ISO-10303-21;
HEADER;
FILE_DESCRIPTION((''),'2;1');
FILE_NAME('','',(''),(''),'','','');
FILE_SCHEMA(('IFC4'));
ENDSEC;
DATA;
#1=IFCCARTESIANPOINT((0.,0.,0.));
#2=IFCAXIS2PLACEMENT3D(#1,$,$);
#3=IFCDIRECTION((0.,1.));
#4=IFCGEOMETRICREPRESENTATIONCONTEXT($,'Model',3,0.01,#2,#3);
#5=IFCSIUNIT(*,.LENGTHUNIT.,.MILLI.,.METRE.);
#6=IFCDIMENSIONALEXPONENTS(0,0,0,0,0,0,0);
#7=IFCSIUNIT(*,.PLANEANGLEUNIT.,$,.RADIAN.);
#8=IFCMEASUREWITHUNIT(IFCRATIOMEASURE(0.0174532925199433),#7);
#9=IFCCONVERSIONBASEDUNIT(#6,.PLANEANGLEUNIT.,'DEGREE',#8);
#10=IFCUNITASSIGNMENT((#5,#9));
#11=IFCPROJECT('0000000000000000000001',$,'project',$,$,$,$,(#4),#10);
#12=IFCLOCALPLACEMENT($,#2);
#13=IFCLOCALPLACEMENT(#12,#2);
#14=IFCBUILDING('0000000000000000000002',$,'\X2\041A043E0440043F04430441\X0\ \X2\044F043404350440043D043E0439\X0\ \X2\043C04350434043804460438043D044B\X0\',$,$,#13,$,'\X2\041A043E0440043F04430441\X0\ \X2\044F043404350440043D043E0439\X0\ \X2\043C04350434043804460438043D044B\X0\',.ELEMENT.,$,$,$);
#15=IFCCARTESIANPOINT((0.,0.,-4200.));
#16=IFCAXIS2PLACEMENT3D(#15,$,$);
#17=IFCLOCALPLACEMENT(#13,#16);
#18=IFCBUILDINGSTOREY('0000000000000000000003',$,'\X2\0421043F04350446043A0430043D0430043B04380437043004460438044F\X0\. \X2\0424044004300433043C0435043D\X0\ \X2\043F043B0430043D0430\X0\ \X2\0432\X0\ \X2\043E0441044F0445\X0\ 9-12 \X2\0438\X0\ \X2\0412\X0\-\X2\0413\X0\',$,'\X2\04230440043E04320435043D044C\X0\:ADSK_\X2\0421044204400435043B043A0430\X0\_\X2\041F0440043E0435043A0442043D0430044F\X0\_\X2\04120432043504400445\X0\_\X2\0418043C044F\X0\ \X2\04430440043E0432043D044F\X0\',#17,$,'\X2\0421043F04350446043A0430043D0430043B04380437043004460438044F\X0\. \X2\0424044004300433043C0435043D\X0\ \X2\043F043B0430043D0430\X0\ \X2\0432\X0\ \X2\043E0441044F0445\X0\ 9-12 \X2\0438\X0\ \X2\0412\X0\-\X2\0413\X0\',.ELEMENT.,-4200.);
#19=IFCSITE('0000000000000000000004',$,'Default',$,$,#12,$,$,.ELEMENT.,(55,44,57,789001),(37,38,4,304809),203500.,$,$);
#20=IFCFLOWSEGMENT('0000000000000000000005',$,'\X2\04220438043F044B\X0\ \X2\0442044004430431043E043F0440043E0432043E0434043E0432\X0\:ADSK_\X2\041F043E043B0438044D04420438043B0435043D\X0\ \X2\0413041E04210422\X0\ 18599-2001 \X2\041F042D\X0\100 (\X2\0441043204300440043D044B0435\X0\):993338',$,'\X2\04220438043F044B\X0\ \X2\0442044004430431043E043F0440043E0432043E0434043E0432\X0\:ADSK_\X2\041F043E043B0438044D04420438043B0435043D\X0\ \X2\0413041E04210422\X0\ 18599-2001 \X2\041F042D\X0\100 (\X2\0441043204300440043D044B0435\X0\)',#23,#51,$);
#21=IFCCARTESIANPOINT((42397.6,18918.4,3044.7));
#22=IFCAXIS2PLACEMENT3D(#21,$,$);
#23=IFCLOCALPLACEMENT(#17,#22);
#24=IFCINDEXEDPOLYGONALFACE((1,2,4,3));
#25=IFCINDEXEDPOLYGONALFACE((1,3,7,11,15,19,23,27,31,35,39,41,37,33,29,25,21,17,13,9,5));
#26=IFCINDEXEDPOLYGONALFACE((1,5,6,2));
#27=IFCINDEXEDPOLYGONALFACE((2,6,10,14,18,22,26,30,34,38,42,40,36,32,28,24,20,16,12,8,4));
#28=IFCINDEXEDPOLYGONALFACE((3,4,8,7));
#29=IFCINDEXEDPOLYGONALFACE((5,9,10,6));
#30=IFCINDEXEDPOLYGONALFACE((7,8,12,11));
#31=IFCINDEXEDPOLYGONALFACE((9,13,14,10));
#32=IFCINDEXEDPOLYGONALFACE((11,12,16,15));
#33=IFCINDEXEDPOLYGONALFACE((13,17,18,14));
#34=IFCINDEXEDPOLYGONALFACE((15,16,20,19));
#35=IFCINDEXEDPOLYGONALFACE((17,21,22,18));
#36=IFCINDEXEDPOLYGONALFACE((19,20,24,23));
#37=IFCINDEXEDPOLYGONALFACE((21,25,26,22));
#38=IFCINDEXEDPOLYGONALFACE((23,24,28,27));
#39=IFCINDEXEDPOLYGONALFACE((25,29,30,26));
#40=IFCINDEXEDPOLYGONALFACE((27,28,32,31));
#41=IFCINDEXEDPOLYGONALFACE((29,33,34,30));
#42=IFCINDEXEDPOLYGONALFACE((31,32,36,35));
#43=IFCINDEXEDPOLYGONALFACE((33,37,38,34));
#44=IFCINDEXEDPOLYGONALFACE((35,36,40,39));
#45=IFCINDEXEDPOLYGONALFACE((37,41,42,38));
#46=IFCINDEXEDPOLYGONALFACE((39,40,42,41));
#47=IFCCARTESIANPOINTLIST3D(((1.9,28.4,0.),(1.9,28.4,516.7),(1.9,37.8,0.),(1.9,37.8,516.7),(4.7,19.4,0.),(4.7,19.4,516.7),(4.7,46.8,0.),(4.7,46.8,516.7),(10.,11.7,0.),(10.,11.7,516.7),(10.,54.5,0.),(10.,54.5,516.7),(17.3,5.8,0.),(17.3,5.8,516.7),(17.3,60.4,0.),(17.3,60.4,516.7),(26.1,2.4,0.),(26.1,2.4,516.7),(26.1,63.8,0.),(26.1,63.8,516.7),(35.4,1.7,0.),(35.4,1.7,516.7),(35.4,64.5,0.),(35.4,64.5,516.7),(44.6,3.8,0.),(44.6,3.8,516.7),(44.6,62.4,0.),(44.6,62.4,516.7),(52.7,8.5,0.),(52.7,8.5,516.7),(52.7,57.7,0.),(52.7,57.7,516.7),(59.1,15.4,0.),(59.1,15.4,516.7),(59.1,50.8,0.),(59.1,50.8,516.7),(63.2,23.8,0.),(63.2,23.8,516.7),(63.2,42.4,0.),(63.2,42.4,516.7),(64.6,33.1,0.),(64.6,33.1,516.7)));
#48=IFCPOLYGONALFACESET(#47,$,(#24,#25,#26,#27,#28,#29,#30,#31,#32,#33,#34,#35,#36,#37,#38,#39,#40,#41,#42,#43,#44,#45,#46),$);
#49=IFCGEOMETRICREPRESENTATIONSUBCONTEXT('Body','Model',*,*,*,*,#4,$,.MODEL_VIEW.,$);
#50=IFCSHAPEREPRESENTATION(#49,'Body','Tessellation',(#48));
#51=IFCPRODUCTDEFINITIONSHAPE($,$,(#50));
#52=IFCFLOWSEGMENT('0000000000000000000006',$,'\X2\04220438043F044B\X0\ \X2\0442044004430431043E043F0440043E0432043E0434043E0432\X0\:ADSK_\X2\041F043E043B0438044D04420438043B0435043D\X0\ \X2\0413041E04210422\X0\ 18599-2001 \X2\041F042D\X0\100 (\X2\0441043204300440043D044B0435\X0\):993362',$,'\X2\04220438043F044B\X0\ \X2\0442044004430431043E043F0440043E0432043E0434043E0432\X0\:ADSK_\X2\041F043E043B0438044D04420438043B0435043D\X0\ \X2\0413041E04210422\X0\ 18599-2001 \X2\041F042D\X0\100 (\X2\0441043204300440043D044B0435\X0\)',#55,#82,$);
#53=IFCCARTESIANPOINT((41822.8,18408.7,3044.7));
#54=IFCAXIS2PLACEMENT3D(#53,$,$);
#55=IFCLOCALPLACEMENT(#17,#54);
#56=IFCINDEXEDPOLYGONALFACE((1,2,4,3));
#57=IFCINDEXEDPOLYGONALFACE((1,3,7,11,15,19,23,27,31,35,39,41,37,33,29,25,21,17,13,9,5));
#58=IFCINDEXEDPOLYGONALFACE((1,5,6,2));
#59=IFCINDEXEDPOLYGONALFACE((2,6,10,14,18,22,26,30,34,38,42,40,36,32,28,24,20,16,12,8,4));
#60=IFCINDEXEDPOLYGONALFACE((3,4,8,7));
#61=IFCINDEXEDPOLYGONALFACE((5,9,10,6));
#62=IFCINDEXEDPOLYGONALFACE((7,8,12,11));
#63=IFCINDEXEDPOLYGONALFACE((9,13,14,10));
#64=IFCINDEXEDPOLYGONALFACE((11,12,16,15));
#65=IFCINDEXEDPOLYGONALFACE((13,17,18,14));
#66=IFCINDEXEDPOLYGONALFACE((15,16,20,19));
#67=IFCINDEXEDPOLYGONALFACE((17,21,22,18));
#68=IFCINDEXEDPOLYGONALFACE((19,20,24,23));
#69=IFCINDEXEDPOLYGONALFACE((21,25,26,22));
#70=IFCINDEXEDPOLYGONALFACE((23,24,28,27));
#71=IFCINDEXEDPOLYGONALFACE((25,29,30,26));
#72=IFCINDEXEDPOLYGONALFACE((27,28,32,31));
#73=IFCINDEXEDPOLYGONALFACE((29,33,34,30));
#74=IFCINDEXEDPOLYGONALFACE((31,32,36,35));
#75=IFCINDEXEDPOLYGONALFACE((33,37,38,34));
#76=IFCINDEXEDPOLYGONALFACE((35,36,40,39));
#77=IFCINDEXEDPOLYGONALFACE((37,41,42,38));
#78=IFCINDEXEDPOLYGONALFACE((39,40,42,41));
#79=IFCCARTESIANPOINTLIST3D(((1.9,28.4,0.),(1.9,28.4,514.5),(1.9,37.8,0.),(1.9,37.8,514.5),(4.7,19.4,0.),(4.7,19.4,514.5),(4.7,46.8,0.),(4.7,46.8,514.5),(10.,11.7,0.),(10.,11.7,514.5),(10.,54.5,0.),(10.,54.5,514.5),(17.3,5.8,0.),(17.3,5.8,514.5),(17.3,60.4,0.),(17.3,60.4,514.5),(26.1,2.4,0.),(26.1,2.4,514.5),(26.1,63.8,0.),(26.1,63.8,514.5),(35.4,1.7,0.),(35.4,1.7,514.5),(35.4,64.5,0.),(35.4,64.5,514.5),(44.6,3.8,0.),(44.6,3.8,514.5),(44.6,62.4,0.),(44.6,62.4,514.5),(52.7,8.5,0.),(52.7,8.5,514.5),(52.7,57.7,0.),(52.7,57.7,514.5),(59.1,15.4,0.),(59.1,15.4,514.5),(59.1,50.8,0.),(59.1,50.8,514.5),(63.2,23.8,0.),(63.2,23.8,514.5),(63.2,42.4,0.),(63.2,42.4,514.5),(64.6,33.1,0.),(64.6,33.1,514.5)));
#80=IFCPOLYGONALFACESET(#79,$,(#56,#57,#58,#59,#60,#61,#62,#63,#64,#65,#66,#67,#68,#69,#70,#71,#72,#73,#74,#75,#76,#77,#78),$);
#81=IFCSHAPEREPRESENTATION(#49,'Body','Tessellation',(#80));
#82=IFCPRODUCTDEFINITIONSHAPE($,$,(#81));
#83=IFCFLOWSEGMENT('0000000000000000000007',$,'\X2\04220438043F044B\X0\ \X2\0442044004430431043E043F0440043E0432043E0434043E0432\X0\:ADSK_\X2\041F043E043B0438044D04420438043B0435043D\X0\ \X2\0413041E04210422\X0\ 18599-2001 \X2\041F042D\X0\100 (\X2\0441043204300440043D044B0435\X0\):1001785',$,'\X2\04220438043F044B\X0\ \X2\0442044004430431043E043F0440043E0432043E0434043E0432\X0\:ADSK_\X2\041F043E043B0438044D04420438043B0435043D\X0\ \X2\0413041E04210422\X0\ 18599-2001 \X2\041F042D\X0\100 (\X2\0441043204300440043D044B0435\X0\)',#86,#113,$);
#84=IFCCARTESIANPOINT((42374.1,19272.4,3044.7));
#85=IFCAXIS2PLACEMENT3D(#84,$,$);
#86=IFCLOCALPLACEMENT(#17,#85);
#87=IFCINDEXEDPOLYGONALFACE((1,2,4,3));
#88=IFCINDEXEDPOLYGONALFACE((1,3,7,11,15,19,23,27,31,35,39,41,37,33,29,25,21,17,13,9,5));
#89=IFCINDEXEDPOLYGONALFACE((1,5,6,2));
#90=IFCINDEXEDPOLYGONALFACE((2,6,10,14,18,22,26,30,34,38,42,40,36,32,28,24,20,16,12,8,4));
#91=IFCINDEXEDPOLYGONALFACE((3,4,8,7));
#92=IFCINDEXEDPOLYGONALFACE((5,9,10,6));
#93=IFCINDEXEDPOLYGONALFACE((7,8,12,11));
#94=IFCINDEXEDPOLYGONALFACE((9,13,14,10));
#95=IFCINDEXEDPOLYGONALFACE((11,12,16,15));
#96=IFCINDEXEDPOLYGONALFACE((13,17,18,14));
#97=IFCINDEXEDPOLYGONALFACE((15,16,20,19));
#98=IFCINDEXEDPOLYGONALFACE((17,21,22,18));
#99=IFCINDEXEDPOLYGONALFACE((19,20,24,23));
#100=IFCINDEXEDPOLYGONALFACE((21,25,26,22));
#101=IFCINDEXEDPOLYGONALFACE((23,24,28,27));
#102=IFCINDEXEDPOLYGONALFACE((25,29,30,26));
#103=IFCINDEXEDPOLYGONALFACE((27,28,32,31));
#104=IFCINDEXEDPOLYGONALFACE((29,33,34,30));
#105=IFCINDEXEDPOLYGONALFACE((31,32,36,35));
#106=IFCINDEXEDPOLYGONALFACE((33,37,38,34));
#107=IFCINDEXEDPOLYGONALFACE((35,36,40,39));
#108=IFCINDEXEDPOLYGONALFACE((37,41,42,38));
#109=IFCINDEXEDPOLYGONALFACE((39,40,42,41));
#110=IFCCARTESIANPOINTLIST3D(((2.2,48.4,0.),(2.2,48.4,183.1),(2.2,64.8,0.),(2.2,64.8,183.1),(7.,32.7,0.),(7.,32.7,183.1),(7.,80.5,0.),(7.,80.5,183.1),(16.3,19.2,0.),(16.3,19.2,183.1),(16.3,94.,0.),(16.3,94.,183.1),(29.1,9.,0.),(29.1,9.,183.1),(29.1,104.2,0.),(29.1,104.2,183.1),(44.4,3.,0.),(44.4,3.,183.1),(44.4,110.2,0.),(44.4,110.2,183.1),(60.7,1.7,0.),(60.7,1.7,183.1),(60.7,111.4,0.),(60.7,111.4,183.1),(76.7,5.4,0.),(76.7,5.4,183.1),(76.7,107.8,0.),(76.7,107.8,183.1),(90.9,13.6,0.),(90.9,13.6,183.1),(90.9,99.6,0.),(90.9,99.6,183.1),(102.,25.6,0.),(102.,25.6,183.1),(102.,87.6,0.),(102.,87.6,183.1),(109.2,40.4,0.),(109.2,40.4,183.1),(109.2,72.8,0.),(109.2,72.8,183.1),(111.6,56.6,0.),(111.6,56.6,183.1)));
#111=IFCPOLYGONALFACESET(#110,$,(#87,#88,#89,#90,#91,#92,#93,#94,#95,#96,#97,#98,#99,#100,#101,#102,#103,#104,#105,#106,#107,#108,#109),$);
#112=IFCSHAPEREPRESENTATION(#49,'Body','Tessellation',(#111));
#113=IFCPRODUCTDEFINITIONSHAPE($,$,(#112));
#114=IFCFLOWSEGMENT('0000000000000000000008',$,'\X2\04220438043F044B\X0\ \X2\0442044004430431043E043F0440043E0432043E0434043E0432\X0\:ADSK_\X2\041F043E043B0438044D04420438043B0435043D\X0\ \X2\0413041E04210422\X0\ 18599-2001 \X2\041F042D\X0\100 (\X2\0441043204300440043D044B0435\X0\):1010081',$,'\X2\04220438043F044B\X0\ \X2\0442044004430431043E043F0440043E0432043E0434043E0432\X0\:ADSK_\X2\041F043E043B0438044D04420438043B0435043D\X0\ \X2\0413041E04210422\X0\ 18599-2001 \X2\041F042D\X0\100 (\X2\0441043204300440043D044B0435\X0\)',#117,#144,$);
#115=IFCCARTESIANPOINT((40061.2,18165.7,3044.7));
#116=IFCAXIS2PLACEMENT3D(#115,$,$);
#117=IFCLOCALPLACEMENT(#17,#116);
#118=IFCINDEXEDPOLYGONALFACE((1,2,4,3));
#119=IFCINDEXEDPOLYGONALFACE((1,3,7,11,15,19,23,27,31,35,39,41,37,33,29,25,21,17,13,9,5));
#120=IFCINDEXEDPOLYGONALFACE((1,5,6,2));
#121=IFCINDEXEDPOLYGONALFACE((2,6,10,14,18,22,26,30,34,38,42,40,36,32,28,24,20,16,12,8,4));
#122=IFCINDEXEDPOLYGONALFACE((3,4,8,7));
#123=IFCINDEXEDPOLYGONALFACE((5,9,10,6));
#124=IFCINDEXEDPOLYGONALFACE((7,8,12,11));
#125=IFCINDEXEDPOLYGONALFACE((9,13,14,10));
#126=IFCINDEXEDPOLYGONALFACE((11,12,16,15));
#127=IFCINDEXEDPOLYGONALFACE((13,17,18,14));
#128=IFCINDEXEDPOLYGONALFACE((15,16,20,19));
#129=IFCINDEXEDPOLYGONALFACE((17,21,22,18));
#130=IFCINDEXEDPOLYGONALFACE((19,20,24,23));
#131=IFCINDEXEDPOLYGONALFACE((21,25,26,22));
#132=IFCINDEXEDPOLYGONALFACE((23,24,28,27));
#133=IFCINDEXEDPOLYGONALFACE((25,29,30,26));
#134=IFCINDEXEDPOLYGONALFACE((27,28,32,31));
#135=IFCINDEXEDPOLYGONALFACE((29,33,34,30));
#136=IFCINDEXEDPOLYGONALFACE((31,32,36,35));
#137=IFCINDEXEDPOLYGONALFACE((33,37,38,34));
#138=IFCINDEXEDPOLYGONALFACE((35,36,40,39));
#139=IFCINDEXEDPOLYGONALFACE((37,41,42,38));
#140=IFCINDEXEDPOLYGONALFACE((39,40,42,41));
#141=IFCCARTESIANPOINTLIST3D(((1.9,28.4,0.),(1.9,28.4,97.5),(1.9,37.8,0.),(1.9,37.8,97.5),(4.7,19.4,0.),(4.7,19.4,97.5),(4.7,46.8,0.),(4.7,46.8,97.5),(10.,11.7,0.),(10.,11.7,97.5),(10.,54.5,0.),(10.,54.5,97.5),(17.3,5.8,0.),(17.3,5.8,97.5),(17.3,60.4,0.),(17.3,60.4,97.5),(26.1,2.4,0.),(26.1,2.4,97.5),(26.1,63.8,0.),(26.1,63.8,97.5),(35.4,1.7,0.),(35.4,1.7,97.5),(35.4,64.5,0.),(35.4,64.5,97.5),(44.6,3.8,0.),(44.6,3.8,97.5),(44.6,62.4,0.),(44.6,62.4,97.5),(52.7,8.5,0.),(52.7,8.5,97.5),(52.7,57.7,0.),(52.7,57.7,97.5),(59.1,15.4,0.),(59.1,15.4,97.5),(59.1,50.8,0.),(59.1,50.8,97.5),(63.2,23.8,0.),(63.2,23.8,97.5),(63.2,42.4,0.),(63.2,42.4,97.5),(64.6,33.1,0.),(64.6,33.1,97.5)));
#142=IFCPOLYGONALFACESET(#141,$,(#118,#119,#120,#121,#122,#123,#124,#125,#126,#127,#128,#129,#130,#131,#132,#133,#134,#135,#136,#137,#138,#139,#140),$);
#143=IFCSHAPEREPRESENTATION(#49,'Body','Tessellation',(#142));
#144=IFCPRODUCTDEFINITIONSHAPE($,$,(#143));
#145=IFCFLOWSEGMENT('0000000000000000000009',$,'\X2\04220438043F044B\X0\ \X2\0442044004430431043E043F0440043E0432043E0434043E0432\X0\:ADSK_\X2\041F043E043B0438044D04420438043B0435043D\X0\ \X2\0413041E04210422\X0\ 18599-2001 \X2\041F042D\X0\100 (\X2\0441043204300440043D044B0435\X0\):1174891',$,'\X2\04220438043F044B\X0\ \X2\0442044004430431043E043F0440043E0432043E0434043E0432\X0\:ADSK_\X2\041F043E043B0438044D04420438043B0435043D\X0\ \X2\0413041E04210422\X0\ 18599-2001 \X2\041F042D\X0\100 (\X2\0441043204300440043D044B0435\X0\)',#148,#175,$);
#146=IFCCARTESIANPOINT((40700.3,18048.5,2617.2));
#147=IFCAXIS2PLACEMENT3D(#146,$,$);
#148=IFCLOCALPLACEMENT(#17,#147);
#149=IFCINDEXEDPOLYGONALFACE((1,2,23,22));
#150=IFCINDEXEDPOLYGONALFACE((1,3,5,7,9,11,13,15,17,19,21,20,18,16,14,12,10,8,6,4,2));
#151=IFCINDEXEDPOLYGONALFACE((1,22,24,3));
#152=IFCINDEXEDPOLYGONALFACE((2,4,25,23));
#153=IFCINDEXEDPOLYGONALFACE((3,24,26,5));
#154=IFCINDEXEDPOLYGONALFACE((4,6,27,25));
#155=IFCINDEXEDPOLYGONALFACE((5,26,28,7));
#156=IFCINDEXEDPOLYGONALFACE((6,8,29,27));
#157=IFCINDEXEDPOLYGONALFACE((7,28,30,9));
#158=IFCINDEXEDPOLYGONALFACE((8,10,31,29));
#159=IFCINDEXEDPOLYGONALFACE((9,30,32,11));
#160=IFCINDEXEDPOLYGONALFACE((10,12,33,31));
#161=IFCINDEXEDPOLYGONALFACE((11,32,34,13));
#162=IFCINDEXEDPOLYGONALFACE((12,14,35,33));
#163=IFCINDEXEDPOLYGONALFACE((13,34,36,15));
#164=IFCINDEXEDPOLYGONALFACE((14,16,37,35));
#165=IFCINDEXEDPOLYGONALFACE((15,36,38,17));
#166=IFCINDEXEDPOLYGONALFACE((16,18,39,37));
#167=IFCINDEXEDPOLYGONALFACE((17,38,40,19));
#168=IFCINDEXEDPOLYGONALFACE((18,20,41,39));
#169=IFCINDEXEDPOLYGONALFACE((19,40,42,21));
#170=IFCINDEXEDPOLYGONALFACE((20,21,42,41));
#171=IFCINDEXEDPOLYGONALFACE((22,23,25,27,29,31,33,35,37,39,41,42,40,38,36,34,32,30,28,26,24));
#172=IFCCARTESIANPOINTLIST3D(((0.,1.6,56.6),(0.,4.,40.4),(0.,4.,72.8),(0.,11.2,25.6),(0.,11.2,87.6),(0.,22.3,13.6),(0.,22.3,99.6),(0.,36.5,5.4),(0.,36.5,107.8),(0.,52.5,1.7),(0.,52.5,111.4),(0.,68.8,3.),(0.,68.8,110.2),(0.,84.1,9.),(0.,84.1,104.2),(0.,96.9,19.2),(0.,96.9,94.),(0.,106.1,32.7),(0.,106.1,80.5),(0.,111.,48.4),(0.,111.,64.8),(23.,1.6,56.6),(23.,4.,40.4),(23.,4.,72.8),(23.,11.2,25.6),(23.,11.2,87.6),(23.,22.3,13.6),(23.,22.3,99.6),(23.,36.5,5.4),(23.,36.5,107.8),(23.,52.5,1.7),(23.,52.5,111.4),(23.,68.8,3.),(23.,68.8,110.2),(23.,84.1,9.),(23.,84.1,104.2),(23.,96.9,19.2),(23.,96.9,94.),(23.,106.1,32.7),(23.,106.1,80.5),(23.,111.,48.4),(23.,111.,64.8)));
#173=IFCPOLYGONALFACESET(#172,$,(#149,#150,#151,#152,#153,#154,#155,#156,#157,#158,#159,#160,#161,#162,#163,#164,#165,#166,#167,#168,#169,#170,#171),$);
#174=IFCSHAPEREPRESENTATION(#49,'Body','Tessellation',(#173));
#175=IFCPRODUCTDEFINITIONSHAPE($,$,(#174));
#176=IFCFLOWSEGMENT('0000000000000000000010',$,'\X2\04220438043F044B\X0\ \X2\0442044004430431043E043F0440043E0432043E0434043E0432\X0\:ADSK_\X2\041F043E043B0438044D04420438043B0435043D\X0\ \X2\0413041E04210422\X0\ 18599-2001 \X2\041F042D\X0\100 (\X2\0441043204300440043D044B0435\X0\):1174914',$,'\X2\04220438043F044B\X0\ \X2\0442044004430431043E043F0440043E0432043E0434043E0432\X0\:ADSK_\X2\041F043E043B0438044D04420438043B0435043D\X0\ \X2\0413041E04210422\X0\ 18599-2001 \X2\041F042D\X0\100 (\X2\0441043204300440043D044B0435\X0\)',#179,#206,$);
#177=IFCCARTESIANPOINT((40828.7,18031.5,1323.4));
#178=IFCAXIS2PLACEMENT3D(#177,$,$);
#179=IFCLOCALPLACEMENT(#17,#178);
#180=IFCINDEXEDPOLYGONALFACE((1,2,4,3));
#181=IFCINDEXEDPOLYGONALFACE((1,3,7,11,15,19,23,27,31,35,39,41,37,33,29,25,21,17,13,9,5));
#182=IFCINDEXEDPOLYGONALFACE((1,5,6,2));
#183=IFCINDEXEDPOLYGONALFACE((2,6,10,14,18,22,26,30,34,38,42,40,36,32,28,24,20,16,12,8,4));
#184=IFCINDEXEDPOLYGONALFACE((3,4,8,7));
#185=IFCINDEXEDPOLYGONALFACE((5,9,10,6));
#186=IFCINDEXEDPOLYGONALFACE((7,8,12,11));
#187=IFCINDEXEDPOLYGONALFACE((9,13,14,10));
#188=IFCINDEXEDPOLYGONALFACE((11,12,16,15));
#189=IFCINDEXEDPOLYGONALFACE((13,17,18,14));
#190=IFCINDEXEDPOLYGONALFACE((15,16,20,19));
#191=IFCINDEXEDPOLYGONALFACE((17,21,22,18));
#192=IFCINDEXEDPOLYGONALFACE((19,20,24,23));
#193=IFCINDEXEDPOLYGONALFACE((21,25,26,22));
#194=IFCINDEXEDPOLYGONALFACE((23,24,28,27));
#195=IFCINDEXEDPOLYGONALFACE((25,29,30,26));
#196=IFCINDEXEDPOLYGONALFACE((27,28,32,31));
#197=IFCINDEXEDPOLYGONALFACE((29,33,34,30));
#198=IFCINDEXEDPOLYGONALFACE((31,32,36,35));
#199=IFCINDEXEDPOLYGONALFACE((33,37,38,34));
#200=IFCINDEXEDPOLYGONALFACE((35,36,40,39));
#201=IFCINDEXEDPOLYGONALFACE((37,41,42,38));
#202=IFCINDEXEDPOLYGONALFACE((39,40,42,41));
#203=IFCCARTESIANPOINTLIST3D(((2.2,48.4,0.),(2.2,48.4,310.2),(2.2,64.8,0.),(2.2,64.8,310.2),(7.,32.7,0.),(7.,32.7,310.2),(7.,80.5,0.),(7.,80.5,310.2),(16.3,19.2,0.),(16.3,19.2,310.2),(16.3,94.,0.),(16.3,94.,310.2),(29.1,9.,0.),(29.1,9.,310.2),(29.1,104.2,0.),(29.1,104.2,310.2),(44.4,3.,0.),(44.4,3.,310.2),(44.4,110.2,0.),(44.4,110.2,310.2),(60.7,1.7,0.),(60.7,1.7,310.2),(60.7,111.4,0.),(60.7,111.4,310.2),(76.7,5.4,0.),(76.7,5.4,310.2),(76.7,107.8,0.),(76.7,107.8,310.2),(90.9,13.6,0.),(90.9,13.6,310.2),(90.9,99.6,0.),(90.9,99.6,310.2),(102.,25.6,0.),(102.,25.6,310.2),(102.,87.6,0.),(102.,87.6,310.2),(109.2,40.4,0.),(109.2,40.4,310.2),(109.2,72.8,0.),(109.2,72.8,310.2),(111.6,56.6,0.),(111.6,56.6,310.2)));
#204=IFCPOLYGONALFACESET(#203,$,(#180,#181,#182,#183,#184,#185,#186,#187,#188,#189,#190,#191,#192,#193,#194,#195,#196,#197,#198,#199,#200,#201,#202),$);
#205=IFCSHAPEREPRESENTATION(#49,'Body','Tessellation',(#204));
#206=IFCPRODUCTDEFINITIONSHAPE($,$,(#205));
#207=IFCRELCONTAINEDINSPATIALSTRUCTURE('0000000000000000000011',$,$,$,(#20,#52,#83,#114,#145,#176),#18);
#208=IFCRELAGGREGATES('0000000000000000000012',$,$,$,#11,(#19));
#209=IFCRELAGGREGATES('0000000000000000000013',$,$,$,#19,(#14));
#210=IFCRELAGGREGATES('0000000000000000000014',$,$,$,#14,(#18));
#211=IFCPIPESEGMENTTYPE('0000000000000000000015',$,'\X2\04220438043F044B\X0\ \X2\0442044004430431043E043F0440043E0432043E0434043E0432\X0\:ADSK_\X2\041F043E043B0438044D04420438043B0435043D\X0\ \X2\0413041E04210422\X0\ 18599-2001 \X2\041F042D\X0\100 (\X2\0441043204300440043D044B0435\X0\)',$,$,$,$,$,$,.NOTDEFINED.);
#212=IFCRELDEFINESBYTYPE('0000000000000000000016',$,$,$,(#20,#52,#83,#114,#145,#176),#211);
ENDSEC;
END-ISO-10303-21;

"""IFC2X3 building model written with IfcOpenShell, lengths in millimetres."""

from ifc_helpers import new_model, entity, si_unit, converted_unit, direction, frame, frame_2d, origin, origin_2d_with_axis, place, context, subcontext, project, spatial, circle, extrude, type_object, element, save


model = new_model("IFC2X3")

# Units and contexts
model_context = context("Model", 3, precision=0.01, world=origin(), true_north=direction((0.0, 1.0)))
body_context = subcontext(model_context, "Body", "Model", "MODEL_VIEW")
ifc_project = project(units=[si_unit("LENGTHUNIT", "METRE", prefix="MILLI"), converted_unit("PLANEANGLEUNIT", "DEGREE", entity("IfcRatioMeasure", 0.0174532925199433), si_unit("PLANEANGLEUNIT", "RADIAN"), dimensions=[0, 0, 0, 0, 0, 0, 0])], contexts=[model_context])

# Site, building, storey
site_placement = place(None, frame((0.0, 0.0, 0.0)))
site = spatial("IfcSite", under=ifc_project, at=site_placement, Name="Default", CompositionType="ELEMENT", RefLatitude=(55, 44, 57, 789001), RefLongitude=(37, 38, 4, 304809), RefElevation=203500.0)
building_placement = place(site_placement, origin())
building = spatial("IfcBuilding", under=site, at=building_placement, Name="Корпус ядерной медицины", LongName="Корпус ядерной медицины", CompositionType="ELEMENT")
storey_placement = place(building_placement, frame((0.0, 0.0, -4200.0)))
storey = spatial("IfcBuildingStorey", under=building, at=storey_placement, Name="Спецканализация. Фрагмен плана в осях 9-12 и В-Г", ObjectType="Уровень:ADSK_Стрелка_Проектная_Вверх_Имя уровня", LongName="Спецканализация. Фрагмен плана в осях 9-12 и В-Г", CompositionType="ELEMENT", Elevation=-4200.0)

# Flow segments
pipe_segment_type = type_object("IfcPipeSegmentType", Name="Типы трубопроводов:ADSK_Полиэтилен ГОСТ 18599-2001 ПЭ100 (сварные)", PredefinedType="NOTDEFINED")
flow_segment_1_placement = place(storey_placement, frame((42397.6, 18918.4, 3044.7)))
element("IfcFlowSegment", 1, at=flow_segment_1_placement, inside=storey, type_object=pipe_segment_type, Name="Типы трубопроводов:ADSK_Полиэтилен ГОСТ 18599-2001 ПЭ100 (сварные):993338", ObjectType="Типы трубопроводов:ADSK_Полиэтилен ГОСТ 18599-2001 ПЭ100 (сварные)", context=body_context, shape_type="SweptSolid", body=[
    extrude(circle(Radius=31.5, at=frame_2d((0.0, 0.0), x_axis=(1.0, 0.0))), frame((33.1, 33.1, 0.0)), (0.0, 0.0, 1.0), 516.7),
])
flow_segment_2_placement = place(storey_placement, frame((41822.8, 18408.7, 3044.7)))
element("IfcFlowSegment", 2, at=flow_segment_2_placement, inside=storey, type_object=pipe_segment_type, Name="Типы трубопроводов:ADSK_Полиэтилен ГОСТ 18599-2001 ПЭ100 (сварные):993362", ObjectType="Типы трубопроводов:ADSK_Полиэтилен ГОСТ 18599-2001 ПЭ100 (сварные)", context=body_context, shape_type="SweptSolid", body=[
    extrude(circle(Radius=31.5, at=origin_2d_with_axis()), frame((33.1, 33.1, 0.0)), (0.0, 0.0, 1.0), 514.5),
])
flow_segment_3_placement = place(storey_placement, frame((42374.1, 19272.4, 3044.7)))
element("IfcFlowSegment", 3, at=flow_segment_3_placement, inside=storey, type_object=pipe_segment_type, Name="Типы трубопроводов:ADSK_Полиэтилен ГОСТ 18599-2001 ПЭ100 (сварные):1001785", ObjectType="Типы трубопроводов:ADSK_Полиэтилен ГОСТ 18599-2001 ПЭ100 (сварные)", context=body_context, shape_type="SweptSolid", body=[
    extrude(circle(Radius=55.0, at=origin_2d_with_axis()), frame((56.6, 56.6, 0.0)), (0.0, 0.0, 1.0), 183.1),
])
flow_segment_4_placement = place(storey_placement, frame((40061.2, 18165.7, 3044.7)))
element("IfcFlowSegment", 4, at=flow_segment_4_placement, inside=storey, type_object=pipe_segment_type, Name="Типы трубопроводов:ADSK_Полиэтилен ГОСТ 18599-2001 ПЭ100 (сварные):1010081", ObjectType="Типы трубопроводов:ADSK_Полиэтилен ГОСТ 18599-2001 ПЭ100 (сварные)", context=body_context, shape_type="SweptSolid", body=[
    extrude(circle(Radius=31.5, at=origin_2d_with_axis()), frame((33.1, 33.1, 0.0)), (0.0, 0.0, 1.0), 97.5),
])
flow_segment_5_placement = place(storey_placement, frame((40700.3, 18048.5, 2617.2)))
element("IfcFlowSegment", 5, at=flow_segment_5_placement, inside=storey, type_object=pipe_segment_type, Name="Типы трубопроводов:ADSK_Полиэтилен ГОСТ 18599-2001 ПЭ100 (сварные):1174891", ObjectType="Типы трубопроводов:ADSK_Полиэтилен ГОСТ 18599-2001 ПЭ100 (сварные)", context=body_context, shape_type="SweptSolid", body=[
    extrude(circle(Radius=55.0, at=origin_2d_with_axis()), frame((0.0, 56.6, 56.6), z_axis=(1.0, 0.0, 0.0), x_axis=(0.0, -1.0, 0.0)), (0.0, 0.0, 1.0), 23.0),
])
flow_segment_6_placement = place(storey_placement, frame((40828.7, 18031.5, 1323.4)))
element("IfcFlowSegment", 6, at=flow_segment_6_placement, inside=storey, type_object=pipe_segment_type, Name="Типы трубопроводов:ADSK_Полиэтилен ГОСТ 18599-2001 ПЭ100 (сварные):1174914", ObjectType="Типы трубопроводов:ADSK_Полиэтилен ГОСТ 18599-2001 ПЭ100 (сварные)", context=body_context, shape_type="SweptSolid", body=[
    extrude(circle(Radius=55.0, at=origin_2d_with_axis()), frame((56.6, 56.6, 0.0)), (0.0, 0.0, 1.0), 310.2),
])

save(model, "model.ifc")
